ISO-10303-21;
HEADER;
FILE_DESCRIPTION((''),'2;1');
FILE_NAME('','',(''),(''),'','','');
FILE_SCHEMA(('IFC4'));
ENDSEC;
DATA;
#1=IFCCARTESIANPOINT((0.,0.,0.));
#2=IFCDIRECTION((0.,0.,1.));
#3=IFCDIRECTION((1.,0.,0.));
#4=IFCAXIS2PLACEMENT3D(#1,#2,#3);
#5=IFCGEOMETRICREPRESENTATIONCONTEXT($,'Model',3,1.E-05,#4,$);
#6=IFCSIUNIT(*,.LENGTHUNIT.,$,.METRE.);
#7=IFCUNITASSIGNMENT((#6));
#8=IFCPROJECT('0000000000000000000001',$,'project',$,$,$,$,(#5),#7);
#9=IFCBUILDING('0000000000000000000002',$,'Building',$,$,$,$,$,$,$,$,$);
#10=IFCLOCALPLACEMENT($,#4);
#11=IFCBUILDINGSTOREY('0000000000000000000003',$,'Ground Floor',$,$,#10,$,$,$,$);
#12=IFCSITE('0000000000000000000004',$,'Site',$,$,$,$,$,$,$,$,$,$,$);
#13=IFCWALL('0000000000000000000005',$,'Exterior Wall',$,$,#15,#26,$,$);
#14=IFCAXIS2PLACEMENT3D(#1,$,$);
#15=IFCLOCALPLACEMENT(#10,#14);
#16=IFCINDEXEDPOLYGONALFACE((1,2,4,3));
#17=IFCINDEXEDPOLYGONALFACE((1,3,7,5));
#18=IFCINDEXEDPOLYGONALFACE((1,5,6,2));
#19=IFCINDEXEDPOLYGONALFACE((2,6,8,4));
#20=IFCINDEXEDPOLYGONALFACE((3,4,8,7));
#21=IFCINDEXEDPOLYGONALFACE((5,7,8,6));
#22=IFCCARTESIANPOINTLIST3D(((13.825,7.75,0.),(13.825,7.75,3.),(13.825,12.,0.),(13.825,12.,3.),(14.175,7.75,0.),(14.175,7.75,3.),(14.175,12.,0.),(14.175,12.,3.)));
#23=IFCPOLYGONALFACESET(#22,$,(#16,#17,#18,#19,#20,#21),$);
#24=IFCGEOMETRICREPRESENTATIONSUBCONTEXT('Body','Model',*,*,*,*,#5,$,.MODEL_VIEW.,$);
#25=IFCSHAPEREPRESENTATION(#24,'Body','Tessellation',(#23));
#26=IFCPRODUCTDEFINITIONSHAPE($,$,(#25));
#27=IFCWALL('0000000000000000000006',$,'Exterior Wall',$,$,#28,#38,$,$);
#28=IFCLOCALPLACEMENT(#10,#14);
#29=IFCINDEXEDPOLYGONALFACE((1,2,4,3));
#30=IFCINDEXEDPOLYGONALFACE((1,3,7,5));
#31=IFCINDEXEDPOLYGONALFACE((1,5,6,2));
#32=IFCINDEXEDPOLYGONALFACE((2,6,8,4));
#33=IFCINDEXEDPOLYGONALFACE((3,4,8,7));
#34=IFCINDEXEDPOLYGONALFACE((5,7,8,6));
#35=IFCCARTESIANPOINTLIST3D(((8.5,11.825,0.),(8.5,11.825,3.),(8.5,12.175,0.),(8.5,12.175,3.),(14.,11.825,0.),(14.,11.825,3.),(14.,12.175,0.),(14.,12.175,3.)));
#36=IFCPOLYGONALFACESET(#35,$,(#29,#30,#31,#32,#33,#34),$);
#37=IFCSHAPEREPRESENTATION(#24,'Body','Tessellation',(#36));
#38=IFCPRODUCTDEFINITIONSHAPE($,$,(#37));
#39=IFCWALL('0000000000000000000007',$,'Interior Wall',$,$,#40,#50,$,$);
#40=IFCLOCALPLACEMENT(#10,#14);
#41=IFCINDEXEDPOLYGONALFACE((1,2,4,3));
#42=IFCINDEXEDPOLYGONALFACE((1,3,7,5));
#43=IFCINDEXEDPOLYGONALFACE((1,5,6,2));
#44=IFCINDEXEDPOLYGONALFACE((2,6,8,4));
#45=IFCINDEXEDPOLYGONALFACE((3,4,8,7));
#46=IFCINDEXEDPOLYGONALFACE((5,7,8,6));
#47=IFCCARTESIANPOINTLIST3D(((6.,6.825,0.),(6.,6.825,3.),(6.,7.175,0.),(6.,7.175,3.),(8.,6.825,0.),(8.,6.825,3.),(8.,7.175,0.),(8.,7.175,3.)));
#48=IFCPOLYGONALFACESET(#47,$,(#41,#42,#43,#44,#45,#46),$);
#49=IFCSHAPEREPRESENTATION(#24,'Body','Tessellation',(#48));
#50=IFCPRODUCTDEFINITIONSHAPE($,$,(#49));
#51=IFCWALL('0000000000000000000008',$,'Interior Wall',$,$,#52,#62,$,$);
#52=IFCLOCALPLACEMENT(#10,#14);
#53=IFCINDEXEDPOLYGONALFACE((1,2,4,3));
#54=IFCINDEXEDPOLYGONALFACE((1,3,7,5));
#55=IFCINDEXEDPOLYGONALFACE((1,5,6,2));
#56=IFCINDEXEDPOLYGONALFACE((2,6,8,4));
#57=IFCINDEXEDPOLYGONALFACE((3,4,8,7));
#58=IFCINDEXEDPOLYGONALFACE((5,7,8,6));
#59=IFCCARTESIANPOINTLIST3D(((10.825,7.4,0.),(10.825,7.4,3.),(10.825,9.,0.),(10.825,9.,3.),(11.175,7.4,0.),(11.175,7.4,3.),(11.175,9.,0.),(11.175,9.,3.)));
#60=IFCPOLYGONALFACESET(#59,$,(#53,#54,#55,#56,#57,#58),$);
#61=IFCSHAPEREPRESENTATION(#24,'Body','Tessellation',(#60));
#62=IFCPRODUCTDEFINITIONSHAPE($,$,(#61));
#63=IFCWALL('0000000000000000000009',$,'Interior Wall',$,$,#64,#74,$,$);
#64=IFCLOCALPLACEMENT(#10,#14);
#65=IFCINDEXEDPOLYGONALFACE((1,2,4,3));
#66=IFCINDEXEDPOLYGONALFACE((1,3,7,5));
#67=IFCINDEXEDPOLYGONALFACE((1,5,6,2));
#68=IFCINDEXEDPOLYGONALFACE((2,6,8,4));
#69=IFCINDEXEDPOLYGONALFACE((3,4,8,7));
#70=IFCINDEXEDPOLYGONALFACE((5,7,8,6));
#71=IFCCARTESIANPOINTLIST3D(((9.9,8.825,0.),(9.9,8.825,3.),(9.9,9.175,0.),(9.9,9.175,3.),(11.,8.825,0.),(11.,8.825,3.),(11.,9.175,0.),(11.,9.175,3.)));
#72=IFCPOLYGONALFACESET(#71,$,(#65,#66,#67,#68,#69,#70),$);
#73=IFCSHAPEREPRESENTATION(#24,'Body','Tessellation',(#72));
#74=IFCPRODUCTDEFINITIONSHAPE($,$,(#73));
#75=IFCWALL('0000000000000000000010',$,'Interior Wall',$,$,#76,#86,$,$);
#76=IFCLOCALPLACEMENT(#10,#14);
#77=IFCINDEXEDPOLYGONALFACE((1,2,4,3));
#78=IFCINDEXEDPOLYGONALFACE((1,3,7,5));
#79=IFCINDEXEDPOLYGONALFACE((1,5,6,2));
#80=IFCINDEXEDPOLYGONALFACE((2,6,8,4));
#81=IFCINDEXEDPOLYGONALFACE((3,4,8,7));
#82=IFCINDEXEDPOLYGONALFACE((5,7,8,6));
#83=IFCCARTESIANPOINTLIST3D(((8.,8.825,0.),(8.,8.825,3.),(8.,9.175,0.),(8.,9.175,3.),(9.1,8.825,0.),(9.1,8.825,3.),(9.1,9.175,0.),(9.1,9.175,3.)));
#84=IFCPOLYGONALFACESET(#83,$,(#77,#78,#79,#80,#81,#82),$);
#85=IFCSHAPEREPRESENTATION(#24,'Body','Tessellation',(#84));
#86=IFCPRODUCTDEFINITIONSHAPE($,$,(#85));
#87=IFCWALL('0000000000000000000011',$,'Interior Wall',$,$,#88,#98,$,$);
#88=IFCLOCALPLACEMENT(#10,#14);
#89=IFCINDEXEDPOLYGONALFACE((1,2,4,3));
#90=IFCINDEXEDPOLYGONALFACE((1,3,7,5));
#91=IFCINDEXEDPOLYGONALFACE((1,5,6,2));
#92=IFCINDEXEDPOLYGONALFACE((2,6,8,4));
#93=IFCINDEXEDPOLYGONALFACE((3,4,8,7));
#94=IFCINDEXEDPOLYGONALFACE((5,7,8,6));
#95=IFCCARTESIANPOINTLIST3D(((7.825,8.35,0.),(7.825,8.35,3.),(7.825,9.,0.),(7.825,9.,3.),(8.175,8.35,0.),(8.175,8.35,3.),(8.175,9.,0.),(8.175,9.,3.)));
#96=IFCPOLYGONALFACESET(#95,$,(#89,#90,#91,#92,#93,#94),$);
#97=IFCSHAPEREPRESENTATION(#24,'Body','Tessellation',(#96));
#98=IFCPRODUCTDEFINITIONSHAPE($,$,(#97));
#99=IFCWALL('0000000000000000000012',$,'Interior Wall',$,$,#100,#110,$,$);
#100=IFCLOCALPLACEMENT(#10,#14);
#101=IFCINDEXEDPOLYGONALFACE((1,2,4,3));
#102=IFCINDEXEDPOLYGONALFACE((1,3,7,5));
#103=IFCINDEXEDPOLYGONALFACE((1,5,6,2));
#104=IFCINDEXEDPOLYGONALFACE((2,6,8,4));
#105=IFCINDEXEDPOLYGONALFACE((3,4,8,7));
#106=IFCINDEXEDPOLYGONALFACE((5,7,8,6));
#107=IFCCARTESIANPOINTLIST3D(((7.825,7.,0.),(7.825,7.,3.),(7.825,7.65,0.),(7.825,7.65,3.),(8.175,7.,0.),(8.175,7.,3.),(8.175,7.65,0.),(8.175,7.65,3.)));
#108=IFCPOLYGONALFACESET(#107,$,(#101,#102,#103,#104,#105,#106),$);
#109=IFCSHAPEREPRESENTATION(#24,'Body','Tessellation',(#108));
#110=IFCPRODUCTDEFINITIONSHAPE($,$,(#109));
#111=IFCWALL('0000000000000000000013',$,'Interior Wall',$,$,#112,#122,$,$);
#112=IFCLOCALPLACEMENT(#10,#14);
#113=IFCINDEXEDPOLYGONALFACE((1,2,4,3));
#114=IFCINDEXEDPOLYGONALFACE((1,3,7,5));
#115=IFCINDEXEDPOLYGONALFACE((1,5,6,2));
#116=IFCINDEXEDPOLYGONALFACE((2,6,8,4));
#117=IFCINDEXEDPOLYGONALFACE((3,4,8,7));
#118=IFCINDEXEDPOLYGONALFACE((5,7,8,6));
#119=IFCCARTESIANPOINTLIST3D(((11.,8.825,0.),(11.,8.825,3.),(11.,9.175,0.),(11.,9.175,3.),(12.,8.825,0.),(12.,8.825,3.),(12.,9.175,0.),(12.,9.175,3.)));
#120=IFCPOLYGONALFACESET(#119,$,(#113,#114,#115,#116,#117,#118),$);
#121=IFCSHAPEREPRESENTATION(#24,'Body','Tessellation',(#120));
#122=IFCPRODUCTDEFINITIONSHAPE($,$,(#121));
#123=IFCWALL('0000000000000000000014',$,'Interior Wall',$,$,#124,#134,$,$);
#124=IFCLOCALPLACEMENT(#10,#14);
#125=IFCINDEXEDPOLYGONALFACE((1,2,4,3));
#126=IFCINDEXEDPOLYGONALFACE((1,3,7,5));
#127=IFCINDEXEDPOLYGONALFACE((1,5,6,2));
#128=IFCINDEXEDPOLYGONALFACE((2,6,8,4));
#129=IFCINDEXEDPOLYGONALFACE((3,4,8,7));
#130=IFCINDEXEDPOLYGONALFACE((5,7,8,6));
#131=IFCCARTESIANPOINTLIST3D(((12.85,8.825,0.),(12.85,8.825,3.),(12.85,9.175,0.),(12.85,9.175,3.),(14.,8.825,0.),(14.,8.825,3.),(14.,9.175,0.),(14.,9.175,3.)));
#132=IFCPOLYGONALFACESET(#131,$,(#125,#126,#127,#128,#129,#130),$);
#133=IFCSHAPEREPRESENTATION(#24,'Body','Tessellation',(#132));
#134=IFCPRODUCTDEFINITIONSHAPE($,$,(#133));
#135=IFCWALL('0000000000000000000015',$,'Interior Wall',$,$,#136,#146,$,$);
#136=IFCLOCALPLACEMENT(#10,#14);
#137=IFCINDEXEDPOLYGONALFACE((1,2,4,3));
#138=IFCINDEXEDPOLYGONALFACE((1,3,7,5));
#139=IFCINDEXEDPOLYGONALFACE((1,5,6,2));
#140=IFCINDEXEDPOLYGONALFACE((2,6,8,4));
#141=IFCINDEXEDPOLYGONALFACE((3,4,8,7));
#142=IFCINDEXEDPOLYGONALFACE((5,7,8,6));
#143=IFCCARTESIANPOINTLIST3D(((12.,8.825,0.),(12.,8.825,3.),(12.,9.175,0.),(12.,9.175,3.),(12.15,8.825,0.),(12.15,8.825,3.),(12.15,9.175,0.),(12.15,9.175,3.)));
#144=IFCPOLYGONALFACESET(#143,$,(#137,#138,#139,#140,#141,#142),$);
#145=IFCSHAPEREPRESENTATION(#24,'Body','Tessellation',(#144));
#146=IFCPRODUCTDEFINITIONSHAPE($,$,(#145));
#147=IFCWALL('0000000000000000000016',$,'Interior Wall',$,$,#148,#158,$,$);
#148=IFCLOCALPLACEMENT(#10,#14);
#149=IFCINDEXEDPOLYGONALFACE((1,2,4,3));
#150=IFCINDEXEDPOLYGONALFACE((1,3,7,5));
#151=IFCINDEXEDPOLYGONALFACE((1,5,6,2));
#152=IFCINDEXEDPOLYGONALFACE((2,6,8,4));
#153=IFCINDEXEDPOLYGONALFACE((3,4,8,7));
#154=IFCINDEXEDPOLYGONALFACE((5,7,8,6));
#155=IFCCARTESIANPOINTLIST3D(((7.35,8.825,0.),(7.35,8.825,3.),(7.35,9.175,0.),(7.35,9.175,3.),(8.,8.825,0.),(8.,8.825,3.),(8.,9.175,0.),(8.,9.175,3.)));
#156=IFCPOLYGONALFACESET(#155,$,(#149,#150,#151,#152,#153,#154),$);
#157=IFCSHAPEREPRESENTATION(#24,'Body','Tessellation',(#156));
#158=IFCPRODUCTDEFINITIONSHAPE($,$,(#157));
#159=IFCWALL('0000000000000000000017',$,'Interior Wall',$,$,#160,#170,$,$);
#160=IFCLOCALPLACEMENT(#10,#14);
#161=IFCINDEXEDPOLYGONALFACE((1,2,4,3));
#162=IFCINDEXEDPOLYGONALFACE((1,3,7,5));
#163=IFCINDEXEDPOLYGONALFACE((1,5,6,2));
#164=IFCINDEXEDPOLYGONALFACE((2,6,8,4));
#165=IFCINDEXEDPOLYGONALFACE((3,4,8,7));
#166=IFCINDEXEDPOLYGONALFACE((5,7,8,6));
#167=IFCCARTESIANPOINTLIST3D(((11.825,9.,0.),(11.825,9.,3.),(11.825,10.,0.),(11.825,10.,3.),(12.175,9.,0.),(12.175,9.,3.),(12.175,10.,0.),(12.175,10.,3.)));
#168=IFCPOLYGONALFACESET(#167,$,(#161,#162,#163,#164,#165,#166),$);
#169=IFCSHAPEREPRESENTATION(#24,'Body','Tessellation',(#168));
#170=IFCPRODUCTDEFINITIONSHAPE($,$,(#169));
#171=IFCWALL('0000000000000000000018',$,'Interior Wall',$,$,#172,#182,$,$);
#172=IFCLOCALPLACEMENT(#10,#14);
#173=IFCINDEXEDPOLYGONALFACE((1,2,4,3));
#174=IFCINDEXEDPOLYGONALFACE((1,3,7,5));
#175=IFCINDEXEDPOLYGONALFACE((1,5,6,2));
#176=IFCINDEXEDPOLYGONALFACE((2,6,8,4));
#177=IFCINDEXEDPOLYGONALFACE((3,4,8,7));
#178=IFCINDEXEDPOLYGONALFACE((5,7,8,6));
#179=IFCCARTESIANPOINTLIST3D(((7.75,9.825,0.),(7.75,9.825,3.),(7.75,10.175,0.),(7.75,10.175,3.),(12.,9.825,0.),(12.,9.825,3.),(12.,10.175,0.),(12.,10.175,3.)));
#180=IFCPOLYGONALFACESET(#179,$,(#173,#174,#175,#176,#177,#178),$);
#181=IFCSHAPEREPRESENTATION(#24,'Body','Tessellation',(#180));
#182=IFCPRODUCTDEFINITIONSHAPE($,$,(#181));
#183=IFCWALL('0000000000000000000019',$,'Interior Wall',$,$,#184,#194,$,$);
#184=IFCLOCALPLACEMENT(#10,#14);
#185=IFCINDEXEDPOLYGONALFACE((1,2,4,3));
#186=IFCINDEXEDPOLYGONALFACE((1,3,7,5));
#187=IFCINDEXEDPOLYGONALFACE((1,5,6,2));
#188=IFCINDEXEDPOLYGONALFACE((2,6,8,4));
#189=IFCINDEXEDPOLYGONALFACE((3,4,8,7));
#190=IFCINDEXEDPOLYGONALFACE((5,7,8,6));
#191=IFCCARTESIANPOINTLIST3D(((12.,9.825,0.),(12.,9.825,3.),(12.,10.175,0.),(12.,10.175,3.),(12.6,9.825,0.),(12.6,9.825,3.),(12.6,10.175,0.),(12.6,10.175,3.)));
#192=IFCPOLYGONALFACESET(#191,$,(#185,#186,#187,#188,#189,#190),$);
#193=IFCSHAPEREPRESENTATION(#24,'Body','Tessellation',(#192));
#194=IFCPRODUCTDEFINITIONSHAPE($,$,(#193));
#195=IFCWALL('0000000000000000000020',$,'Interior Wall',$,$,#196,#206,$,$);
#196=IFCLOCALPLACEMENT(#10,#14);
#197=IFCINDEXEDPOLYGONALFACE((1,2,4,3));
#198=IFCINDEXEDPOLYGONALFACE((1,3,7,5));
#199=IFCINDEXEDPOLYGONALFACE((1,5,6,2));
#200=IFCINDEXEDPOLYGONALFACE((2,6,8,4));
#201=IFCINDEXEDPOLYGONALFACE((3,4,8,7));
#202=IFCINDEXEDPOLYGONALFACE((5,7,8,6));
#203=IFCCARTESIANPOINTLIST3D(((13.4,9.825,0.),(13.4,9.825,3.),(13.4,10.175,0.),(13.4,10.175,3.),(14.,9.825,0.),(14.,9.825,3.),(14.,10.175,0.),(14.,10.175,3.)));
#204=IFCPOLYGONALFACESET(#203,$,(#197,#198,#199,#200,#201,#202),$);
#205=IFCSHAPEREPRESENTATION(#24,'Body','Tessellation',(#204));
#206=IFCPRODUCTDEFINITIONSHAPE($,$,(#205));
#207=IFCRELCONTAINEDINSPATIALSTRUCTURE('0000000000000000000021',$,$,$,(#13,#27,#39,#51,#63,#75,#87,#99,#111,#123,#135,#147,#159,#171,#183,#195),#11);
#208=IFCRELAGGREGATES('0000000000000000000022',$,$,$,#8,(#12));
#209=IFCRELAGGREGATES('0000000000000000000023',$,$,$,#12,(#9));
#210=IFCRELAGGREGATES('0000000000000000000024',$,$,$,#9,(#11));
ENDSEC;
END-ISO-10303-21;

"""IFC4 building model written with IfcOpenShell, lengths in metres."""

from ifc_helpers import new_model, si_unit, frame, origin_with_axes, place, context, subcontext, project, spatial, indexed_curve, outline, extrude, element, save


model = new_model("IFC4")

# Units and contexts
model_context = context("Model", 3, precision=1e-05, world=origin_with_axes())
body_context = subcontext(model_context, "Body", "Model", "MODEL_VIEW")
ifc_project = project(units=[si_unit("LENGTHUNIT", "METRE")], contexts=[model_context])

# Site, building, storey
site = spatial("IfcSite", under=ifc_project, Name="Site")
building = spatial("IfcBuilding", under=site, Name="Building")
storey_placement = place(None, origin_with_axes())
storey = spatial("IfcBuildingStorey", under=building, at=storey_placement, Name="Ground Floor")

# Walls
wall_1_placement = place(storey_placement, frame((14.0, 7.75, 0.0), z_axis=(0.0, 0.0, 1.0), x_axis=(0.0, 1.0, 0.0)))
element("IfcWall", 1, at=wall_1_placement, inside=storey, Name="Exterior Wall", context=body_context, shape_type="SweptSolid", body=[
    extrude(outline(indexed_curve([(0.0, 0.0), (0.0, 0.35), (4.25, 0.35), (4.25, 0.0), (0.0, 0.0)], self_intersect=False)), frame((0.0, -0.175, 0.0), z_axis=(0.0, 0.0, 1.0), x_axis=(1.0, 0.0, 0.0)), (0.0, 0.0, 1.0), 3.0),
])
wall_2_placement = place(storey_placement, frame((14.0, 12.0, 0.0), z_axis=(0.0, 0.0, 1.0), x_axis=(-1.0, 0.0, 0.0)))
element("IfcWall", 2, at=wall_2_placement, inside=storey, Name="Exterior Wall", context=body_context, shape_type="SweptSolid", body=[
    extrude(outline(indexed_curve([(0.0, 0.0), (0.0, 0.35), (5.5, 0.35), (5.5, 0.0), (0.0, 0.0)], self_intersect=False)), frame((0.0, -0.175, 0.0), z_axis=(0.0, 0.0, 1.0), x_axis=(1.0, 0.0, 0.0)), (0.0, 0.0, 1.0), 3.0),
])
wall_3_placement = place(storey_placement, frame((8.0, 7.0, 0.0), z_axis=(0.0, 0.0, 1.0), x_axis=(-1.0, 0.0, 0.0)))
element("IfcWall", 3, at=wall_3_placement, inside=storey, Name="Interior Wall", context=body_context, shape_type="SweptSolid", body=[
    extrude(outline(indexed_curve([(0.0, 0.0), (0.0, 0.35), (2.0, 0.35), (2.0, 0.0), (0.0, 0.0)], self_intersect=False)), frame((0.0, -0.175, 0.0), z_axis=(0.0, 0.0, 1.0), x_axis=(1.0, 0.0, 0.0)), (0.0, 0.0, 1.0), 3.0),
])
wall_4_placement = place(storey_placement, frame((11.0, 7.4, 0.0), z_axis=(0.0, 0.0, 1.0), x_axis=(0.0, 1.0, 0.0)))
element("IfcWall", 4, at=wall_4_placement, inside=storey, Name="Interior Wall", context=body_context, shape_type="SweptSolid", body=[
    extrude(outline(indexed_curve([(0.0, 0.0), (0.0, 0.35), (1.6, 0.35), (1.6, 0.0), (0.0, 0.0)], self_intersect=False)), frame((0.0, -0.175, 0.0), z_axis=(0.0, 0.0, 1.0), x_axis=(1.0, 0.0, 0.0)), (0.0, 0.0, 1.0), 3.0),
])
for number, where, z_axis, x_axis, name in (
    (5, (11.0, 9.0, 0.0), (0.0, 0.0, 1.0), (-1.0, 0.0, 0.0), "Interior Wall"),
    (6, (9.1, 9.0, 0.0), (0.0, 0.0, 1.0), (-1.0, 0.0, 0.0), "Interior Wall"),
):
    element("IfcWall", number, at=place(storey_placement, frame(where, z_axis=z_axis, x_axis=x_axis)), inside=storey, Name=name, context=body_context, shape_type="SweptSolid", body=[
        extrude(outline(indexed_curve([(0.0, 0.0), (0.0, 0.35), (1.1, 0.35), (1.1, 0.0), (0.0, 0.0)], self_intersect=False)), frame((0.0, -0.175, 0.0), z_axis=(0.0, 0.0, 1.0), x_axis=(1.0, 0.0, 0.0)), (0.0, 0.0, 1.0), 3.0),
    ])
for number, where, z_axis, x_axis, name in (
    (7, (8.0, 9.0, 0.0), (0.0, 0.0, 1.0), (0.0, -1.0, 0.0), "Interior Wall"),
    (8, (8.0, 7.65, 0.0), (0.0, 0.0, 1.0), (0.0, -1.0, 0.0), "Interior Wall"),
):
    element("IfcWall", number, at=place(storey_placement, frame(where, z_axis=z_axis, x_axis=x_axis)), inside=storey, Name=name, context=body_context, shape_type="SweptSolid", body=[
        extrude(outline(indexed_curve([(0.0, 0.0), (0.0, 0.35), (0.65, 0.35), (0.65, 0.0), (0.0, 0.0)], self_intersect=False)), frame((0.0, -0.175, 0.0), z_axis=(0.0, 0.0, 1.0), x_axis=(1.0, 0.0, 0.0)), (0.0, 0.0, 1.0), 3.0),
    ])
wall_5_placement = place(storey_placement, frame((12.0, 9.0, 0.0), z_axis=(0.0, 0.0, 1.0), x_axis=(-1.0, 0.0, 0.0)))
element("IfcWall", 9, at=wall_5_placement, inside=storey, Name="Interior Wall", context=body_context, shape_type="SweptSolid", body=[
    extrude(outline(indexed_curve([(0.0, 0.0), (0.0, 0.35), (1.0, 0.35), (1.0, 0.0), (0.0, 0.0)], self_intersect=False)), frame((0.0, -0.175, 0.0), z_axis=(0.0, 0.0, 1.0), x_axis=(1.0, 0.0, 0.0)), (0.0, 0.0, 1.0), 3.0),
])
wall_6_placement = place(storey_placement, frame((14.0, 9.0, 0.0), z_axis=(0.0, 0.0, 1.0), x_axis=(-1.0, 0.0, 0.0)))
element("IfcWall", 10, at=wall_6_placement, inside=storey, Name="Interior Wall", context=body_context, shape_type="SweptSolid", body=[
    extrude(outline(indexed_curve([(0.0, 0.0), (0.0, 0.35), (1.15, 0.35), (1.15, 0.0), (0.0, 0.0)], self_intersect=False)), frame((0.0, -0.175, 0.0), z_axis=(0.0, 0.0, 1.0), x_axis=(1.0, 0.0, 0.0)), (0.0, 0.0, 1.0), 3.0),
])
wall_7_placement = place(storey_placement, frame((12.15, 9.0, 0.0), z_axis=(0.0, 0.0, 1.0), x_axis=(-1.0, 0.0, 0.0)))
element("IfcWall", 11, at=wall_7_placement, inside=storey, Name="Interior Wall", context=body_context, shape_type="SweptSolid", body=[
    extrude(outline(indexed_curve([(0.0, 0.0), (0.0, 0.35), (0.15, 0.35), (0.15, 0.0), (0.0, 0.0)], self_intersect=False)), frame((0.0, -0.175, 0.0), z_axis=(0.0, 0.0, 1.0), x_axis=(1.0, 0.0, 0.0)), (0.0, 0.0, 1.0), 3.0),
])
wall_8_placement = place(storey_placement, frame((8.0, 9.0, 0.0), z_axis=(0.0, 0.0, 1.0), x_axis=(-1.0, 0.0, 0.0)))
element("IfcWall", 12, at=wall_8_placement, inside=storey, Name="Interior Wall", context=body_context, shape_type="SweptSolid", body=[
    extrude(outline(indexed_curve([(0.0, 0.0), (0.0, 0.35), (0.65, 0.35), (0.65, 0.0), (0.0, 0.0)], self_intersect=False)), frame((0.0, -0.175, 0.0), z_axis=(0.0, 0.0, 1.0), x_axis=(1.0, 0.0, 0.0)), (0.0, 0.0, 1.0), 3.0),
])
wall_9_placement = place(storey_placement, frame((12.0, 9.0, 0.0), z_axis=(0.0, 0.0, 1.0), x_axis=(0.0, 1.0, 0.0)))
element("IfcWall", 13, at=wall_9_placement, inside=storey, Name="Interior Wall", context=body_context, shape_type="SweptSolid", body=[
    extrude(outline(indexed_curve([(0.0, 0.0), (0.0, 0.35), (1.0, 0.35), (1.0, 0.0), (0.0, 0.0)], self_intersect=False)), frame((0.0, -0.175, 0.0), z_axis=(0.0, 0.0, 1.0), x_axis=(1.0, 0.0, 0.0)), (0.0, 0.0, 1.0), 3.0),
])
wall_10_placement = place(storey_placement, frame((12.0, 10.0, 0.0), z_axis=(0.0, 0.0, 1.0), x_axis=(-1.0, 0.0, 0.0)))
element("IfcWall", 14, at=wall_10_placement, inside=storey, Name="Interior Wall", context=body_context, shape_type="SweptSolid", body=[
    extrude(outline(indexed_curve([(0.0, 0.0), (0.0, 0.35), (4.25, 0.35), (4.25, 0.0), (0.0, 0.0)], self_intersect=False)), frame((0.0, -0.175, 0.0), z_axis=(0.0, 0.0, 1.0), x_axis=(1.0, 0.0, 0.0)), (0.0, 0.0, 1.0), 3.0),
])
for number, where, z_axis, x_axis, name in (
    (15, (12.0, 10.0, 0.0), (0.0, 0.0, 1.0), (1.0, 0.0, 0.0), "Interior Wall"),
    (16, (13.4, 10.0, 0.0), (0.0, 0.0, 1.0), (1.0, 0.0, 0.0), "Interior Wall"),
):
    element("IfcWall", number, at=place(storey_placement, frame(where, z_axis=z_axis, x_axis=x_axis)), inside=storey, Name=name, context=body_context, shape_type="SweptSolid", body=[
        extrude(outline(indexed_curve([(0.0, 0.0), (0.0, 0.35), (0.6, 0.35), (0.6, 0.0), (0.0, 0.0)], self_intersect=False)), frame((0.0, -0.175, 0.0), z_axis=(0.0, 0.0, 1.0), x_axis=(1.0, 0.0, 0.0)), (0.0, 0.0, 1.0), 3.0),
    ])

save(model, "model.ifc")
